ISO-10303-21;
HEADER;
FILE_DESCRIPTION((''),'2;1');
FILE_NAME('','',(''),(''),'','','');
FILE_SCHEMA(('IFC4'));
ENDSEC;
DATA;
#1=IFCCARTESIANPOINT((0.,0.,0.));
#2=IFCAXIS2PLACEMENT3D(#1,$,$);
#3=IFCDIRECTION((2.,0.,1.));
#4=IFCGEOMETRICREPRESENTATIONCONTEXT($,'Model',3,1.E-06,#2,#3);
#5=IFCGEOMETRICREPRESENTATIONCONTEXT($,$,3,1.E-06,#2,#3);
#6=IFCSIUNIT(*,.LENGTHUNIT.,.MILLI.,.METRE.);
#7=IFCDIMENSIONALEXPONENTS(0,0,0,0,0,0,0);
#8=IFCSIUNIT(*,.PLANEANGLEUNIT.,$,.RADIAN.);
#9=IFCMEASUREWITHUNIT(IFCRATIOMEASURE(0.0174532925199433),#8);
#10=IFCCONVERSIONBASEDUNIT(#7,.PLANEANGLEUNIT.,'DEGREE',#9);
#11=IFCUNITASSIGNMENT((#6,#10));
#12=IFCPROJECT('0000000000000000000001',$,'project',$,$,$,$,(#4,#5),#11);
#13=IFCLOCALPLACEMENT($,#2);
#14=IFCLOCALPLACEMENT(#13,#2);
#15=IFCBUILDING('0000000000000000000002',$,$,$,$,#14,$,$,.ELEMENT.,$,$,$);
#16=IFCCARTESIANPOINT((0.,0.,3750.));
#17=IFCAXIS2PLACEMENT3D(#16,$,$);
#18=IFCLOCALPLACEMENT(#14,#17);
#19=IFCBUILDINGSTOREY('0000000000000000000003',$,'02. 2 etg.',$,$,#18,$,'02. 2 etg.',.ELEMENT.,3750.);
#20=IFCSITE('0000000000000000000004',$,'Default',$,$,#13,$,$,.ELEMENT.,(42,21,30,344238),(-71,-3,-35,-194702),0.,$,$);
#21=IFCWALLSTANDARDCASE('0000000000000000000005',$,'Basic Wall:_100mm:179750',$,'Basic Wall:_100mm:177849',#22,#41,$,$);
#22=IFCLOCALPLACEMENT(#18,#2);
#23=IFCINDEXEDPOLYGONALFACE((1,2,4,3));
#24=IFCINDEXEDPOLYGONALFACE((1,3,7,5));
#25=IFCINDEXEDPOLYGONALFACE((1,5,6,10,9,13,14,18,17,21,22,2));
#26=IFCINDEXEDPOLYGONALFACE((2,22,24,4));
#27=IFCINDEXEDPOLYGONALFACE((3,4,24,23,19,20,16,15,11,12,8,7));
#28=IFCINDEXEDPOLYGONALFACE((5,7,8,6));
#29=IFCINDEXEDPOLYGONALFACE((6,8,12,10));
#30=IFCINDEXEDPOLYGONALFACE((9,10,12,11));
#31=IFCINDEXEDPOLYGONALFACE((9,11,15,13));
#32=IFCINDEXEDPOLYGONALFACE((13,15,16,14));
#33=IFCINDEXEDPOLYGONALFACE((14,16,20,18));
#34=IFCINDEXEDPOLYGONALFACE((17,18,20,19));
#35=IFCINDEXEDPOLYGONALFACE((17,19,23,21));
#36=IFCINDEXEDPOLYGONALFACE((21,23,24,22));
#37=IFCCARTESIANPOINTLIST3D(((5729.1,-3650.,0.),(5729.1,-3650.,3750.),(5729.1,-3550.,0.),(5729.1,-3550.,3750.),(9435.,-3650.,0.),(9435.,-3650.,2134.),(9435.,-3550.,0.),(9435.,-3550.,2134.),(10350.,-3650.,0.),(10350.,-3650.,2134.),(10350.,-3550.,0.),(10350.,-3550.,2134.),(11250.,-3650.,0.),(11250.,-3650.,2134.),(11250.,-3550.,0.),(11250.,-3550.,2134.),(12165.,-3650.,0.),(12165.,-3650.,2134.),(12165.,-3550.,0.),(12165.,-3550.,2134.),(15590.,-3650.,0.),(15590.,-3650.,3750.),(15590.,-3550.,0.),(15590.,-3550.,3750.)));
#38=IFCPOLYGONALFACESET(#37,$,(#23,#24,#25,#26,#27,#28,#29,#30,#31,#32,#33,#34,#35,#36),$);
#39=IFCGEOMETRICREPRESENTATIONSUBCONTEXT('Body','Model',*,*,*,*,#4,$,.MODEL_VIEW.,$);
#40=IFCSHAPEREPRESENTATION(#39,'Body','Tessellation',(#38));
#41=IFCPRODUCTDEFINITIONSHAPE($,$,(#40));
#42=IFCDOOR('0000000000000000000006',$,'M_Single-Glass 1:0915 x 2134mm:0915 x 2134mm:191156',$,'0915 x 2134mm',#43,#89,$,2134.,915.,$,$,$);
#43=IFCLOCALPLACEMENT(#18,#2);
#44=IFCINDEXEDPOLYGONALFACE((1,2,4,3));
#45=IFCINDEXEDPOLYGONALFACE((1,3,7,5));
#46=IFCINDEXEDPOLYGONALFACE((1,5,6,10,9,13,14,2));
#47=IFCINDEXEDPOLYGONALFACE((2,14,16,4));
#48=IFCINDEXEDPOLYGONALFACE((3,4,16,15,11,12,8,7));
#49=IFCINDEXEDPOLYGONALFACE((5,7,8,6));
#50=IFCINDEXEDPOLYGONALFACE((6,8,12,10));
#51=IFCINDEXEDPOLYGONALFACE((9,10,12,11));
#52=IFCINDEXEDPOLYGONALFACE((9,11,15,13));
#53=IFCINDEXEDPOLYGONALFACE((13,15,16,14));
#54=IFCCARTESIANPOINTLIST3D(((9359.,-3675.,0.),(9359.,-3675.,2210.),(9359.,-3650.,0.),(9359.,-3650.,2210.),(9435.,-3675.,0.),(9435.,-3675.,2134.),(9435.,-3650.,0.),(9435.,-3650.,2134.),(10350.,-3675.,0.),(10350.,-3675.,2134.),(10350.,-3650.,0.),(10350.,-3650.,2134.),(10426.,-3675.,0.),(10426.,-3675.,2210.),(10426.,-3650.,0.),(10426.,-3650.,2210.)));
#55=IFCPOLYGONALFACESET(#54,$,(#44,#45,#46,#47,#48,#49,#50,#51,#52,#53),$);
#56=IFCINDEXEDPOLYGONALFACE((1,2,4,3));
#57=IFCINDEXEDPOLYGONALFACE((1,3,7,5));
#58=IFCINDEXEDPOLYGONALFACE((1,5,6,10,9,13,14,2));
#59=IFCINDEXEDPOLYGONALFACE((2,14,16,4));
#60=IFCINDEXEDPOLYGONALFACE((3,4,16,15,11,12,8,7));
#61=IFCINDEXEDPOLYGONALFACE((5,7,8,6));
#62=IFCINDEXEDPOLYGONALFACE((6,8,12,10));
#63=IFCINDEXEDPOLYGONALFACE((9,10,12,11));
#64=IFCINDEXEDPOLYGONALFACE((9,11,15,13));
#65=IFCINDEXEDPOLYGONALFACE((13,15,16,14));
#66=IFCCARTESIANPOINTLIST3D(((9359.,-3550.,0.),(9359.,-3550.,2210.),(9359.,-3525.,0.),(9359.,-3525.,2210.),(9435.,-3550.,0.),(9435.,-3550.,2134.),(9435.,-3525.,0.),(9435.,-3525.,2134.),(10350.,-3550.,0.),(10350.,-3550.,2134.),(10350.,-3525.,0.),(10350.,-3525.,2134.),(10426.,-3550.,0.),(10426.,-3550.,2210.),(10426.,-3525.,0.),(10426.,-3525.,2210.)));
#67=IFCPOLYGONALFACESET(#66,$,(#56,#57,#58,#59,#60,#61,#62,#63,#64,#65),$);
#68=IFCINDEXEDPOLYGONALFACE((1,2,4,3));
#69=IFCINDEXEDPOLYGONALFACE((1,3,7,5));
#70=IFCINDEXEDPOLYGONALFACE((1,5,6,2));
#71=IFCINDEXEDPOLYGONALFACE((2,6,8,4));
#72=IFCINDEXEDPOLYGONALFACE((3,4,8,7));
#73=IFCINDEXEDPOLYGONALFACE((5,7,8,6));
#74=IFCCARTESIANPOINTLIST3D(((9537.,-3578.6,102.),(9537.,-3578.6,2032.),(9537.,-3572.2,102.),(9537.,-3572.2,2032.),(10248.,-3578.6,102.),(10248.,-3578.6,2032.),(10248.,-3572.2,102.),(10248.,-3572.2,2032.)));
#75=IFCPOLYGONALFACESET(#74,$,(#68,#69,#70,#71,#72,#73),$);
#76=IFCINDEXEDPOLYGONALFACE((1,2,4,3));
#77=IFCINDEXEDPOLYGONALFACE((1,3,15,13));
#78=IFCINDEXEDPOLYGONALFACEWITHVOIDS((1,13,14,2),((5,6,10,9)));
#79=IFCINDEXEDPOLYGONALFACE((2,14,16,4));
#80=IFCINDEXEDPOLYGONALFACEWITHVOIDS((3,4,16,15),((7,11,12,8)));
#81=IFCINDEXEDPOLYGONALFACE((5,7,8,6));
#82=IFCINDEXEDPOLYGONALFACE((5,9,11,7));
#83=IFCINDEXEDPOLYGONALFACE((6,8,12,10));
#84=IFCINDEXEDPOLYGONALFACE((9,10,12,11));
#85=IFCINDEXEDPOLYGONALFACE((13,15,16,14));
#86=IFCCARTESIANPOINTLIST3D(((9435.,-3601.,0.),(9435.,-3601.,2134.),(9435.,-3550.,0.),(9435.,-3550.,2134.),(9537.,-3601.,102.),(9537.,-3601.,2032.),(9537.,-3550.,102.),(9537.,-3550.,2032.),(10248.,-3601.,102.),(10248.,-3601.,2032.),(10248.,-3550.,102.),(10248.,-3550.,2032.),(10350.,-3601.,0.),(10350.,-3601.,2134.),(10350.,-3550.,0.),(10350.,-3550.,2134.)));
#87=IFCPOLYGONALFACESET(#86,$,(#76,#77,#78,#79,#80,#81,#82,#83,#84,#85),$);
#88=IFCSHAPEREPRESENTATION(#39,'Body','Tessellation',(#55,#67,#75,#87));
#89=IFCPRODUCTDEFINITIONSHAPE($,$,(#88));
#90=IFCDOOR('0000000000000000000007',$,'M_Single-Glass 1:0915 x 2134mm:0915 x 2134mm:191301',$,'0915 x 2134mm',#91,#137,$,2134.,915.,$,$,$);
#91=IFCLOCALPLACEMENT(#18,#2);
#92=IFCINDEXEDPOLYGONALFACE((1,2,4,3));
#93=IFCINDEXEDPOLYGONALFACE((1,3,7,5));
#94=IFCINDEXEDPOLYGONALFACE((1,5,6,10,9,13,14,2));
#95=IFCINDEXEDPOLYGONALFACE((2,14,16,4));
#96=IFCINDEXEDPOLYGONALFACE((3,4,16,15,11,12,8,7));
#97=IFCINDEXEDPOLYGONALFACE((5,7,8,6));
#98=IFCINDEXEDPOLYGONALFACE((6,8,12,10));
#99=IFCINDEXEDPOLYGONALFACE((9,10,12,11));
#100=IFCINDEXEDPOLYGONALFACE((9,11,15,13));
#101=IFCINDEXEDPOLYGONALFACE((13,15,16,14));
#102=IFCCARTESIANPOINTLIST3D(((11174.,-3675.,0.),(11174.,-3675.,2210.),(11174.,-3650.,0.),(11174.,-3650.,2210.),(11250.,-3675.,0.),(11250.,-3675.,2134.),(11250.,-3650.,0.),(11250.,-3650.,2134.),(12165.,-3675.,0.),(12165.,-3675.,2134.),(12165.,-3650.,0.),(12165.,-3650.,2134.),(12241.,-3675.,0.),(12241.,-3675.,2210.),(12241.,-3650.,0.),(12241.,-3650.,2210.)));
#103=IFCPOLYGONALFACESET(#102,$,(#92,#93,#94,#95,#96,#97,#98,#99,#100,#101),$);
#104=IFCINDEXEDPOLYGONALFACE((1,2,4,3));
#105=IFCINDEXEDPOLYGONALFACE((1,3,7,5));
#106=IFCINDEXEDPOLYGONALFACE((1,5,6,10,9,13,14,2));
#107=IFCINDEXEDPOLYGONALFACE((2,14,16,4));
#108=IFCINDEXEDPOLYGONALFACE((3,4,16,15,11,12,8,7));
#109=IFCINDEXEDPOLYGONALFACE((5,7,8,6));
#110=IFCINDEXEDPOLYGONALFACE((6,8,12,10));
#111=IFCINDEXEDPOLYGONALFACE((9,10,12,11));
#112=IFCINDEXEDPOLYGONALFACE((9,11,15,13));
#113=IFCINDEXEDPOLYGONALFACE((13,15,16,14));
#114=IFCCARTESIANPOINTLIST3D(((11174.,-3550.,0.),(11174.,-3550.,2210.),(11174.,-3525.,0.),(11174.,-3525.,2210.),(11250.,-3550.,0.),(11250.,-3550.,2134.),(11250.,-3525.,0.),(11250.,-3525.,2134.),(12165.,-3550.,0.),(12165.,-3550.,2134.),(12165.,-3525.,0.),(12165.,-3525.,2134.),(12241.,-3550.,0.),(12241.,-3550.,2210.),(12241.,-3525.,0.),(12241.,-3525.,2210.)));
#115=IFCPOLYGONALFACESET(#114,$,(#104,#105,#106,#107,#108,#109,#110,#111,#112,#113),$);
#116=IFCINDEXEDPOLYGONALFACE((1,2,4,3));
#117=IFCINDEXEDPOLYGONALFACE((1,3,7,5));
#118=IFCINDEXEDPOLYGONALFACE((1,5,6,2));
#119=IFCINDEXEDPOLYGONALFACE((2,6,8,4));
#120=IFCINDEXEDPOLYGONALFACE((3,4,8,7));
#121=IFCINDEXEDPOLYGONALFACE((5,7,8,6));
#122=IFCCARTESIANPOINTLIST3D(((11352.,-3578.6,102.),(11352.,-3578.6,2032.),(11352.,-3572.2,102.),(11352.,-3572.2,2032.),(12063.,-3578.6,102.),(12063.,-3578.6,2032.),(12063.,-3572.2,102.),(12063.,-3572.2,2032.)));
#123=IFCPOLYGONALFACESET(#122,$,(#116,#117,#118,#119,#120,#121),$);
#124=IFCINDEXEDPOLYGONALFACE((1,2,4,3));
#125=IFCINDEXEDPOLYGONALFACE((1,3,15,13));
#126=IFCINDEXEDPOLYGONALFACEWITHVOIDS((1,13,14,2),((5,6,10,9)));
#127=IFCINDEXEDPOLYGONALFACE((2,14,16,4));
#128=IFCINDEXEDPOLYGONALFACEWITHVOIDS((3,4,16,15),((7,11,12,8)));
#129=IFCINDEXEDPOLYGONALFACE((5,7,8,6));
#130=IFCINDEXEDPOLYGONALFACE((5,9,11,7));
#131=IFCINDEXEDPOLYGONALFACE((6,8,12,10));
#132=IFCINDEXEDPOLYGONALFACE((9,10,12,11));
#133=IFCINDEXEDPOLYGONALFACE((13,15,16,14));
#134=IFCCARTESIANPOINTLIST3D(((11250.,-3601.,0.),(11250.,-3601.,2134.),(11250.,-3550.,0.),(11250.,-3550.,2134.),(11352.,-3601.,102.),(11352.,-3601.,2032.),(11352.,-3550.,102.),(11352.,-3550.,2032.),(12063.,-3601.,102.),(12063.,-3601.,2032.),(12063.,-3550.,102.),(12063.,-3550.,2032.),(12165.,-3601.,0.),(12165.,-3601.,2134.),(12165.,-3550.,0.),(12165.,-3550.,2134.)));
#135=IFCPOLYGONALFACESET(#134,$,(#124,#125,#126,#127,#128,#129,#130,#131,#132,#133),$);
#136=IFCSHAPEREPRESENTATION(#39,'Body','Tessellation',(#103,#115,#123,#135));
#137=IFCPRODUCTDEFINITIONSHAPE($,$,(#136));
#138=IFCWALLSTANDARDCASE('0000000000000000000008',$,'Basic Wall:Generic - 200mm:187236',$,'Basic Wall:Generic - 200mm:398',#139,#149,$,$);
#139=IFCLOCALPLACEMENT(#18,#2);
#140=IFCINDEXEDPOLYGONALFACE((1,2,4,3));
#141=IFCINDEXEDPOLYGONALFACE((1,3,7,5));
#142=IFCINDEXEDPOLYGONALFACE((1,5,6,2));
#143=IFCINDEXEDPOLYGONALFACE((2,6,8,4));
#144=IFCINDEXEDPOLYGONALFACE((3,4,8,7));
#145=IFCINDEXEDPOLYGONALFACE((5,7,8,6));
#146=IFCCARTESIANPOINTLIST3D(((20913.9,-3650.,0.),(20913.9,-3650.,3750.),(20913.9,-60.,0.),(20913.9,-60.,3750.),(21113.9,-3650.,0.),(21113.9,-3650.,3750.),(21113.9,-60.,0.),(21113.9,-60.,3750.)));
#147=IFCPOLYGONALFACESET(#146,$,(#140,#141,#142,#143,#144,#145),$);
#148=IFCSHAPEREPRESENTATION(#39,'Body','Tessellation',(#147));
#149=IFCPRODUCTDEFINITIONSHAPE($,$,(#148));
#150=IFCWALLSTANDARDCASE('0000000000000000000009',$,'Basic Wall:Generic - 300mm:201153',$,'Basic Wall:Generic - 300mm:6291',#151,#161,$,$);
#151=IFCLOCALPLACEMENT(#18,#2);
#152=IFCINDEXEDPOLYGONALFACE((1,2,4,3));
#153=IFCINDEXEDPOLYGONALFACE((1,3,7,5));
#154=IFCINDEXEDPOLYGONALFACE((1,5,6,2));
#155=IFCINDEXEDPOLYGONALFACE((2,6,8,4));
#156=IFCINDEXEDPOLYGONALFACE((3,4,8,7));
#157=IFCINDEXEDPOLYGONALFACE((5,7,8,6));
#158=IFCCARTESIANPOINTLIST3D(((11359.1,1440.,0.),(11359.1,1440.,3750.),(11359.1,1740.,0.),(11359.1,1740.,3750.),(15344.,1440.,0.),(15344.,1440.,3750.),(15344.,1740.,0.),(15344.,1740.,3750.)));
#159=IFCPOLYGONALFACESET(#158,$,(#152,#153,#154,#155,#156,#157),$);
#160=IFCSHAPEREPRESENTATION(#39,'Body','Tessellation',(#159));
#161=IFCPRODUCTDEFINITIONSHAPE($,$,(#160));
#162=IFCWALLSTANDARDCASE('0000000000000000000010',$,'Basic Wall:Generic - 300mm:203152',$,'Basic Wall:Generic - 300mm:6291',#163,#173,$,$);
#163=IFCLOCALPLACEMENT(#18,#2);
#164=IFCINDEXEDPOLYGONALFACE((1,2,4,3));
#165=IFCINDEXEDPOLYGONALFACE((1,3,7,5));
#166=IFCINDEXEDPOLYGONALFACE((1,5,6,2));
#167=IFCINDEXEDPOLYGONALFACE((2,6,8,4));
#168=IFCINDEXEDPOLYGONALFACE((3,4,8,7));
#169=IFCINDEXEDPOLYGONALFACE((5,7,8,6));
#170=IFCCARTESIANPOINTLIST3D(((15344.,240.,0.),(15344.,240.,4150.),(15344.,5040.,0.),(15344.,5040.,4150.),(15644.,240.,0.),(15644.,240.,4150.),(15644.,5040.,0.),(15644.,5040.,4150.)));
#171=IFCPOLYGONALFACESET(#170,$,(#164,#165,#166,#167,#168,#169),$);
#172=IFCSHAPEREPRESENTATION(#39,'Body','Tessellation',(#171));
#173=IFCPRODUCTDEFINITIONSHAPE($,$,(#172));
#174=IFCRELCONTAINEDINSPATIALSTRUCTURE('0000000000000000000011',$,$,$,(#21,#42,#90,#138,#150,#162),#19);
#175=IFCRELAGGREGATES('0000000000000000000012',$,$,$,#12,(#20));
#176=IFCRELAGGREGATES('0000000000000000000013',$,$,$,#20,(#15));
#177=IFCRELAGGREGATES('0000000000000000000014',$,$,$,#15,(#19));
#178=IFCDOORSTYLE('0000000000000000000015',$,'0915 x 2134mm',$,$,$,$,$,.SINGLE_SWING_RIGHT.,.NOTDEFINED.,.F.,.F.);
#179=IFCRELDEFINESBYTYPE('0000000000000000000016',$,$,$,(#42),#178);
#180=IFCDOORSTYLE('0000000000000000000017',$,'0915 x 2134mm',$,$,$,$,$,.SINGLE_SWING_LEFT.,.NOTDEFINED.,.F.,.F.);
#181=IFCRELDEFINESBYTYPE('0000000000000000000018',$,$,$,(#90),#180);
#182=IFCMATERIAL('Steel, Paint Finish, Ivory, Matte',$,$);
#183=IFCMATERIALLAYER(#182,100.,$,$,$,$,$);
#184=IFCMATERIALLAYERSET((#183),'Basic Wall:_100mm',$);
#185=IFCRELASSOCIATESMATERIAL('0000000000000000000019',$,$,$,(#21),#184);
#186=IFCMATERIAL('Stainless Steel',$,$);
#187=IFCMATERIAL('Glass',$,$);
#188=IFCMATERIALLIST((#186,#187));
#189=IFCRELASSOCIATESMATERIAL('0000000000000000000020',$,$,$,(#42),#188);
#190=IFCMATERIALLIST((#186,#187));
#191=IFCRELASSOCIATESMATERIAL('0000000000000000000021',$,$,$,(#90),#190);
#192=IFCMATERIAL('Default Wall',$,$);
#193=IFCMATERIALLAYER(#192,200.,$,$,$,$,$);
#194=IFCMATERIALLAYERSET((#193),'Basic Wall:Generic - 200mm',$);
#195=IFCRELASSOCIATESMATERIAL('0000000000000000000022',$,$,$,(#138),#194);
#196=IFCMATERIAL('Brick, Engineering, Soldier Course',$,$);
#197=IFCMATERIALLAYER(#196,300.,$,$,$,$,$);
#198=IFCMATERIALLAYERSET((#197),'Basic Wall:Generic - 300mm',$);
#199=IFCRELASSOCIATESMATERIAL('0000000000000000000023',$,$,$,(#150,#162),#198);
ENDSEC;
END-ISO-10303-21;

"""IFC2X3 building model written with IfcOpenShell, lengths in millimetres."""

from ifc_helpers import new_model, entity, si_unit, converted_unit, direction, frame, frame_2d, origin, origin_2d_with_axis, place, context, subcontext, project, spatial, polyline, rectangle, outline, extrude, source, transform, mapped, material, material_list, layer, layer_set, layer_usage, type_object, type_shapes, element, fill, save


model = new_model("IFC2X3")

# Units and contexts
model_context = context("Model", 3, precision=1e-06, world=origin(), true_north=direction((2.0, 0.0, 1.0)))
context_of_model = context(None, 3, precision=1e-06, world=origin(), true_north=direction((2.0, 0.0, 1.0)))
body_context = subcontext(model_context, "Body", "Model", "MODEL_VIEW")
ifc_project = project(units=[si_unit("LENGTHUNIT", "METRE", prefix="MILLI"), converted_unit("PLANEANGLEUNIT", "DEGREE", entity("IfcRatioMeasure", 0.0174532925199433), si_unit("PLANEANGLEUNIT", "RADIAN"), dimensions=[0, 0, 0, 0, 0, 0, 0])], contexts=[model_context, context_of_model])

# Site, building, storey
site_placement = place(None, origin())
site = spatial("IfcSite", under=ifc_project, at=site_placement, Name="Default", CompositionType="ELEMENT", RefLatitude=(42, 21, 30, 344238), RefLongitude=(-71, -3, -35, -194702), RefElevation=0.0)
building_placement = place(site_placement, origin())
building = spatial("IfcBuilding", under=site, at=building_placement, CompositionType="ELEMENT")
storey_placement = place(building_placement, frame((0.0, 0.0, 3750.0)))
storey = spatial("IfcBuildingStorey", under=building, at=storey_placement, Name="02. 2 etg.", LongName="02. 2 etg.", CompositionType="ELEMENT", Elevation=3750.0)

# Shared definitions
ifc_material_1 = material(Name="Glass")

# Wall, openings, doors
ifc_material_2 = material(Name="Steel, Paint Finish, Ivory, Matte")
ifc_layer_1 = layer(ifc_material_2, 100.0)
ifc_layer_set_1 = layer_set([ifc_layer_1], Name="Basic Wall:_100mm")
ifc_layer_usage_1 = layer_usage(ifc_layer_set_1, "AXIS2", "NEGATIVE", 50.0)
wall_1_placement = place(storey_placement, frame((15590.0, -3600.0, 0.0), z_axis=(0.0, 0.0, 1.0), x_axis=(-1.0, 0.0, 0.0)))
wall_1 = element("IfcWallStandardCase", 1, at=wall_1_placement, inside=storey, material=ifc_layer_usage_1, Name="Basic Wall:_100mm:179750", ObjectType="Basic Wall:_100mm:177849", context=body_context, shape_type="SweptSolid", body=[
    extrude(rectangle(XDim=9860.9, YDim=100.0, at=frame_2d((4930.4, 0.0), x_axis=(-1.0, 0.0))), origin(), (0.0, 0.0, 1.0), 3750.0),
])
opening_1_placement = place(wall_1_placement, frame((6155.0, 50.0, 0.0)))
opening_1 = element("IfcOpeningElement", 2, at=opening_1_placement, cuts=wall_1, ObjectType="Opening", context=body_context, shape_type="SweptSolid", body=[
    extrude(rectangle(XDim=915.0, YDim=2134.0, at=frame_2d((1067.0, 457.5), x_axis=(0.0, 1.0))), frame((0.0, 0.0, 0.0), z_axis=(0.0, -1.0, 0.0), x_axis=(0.0, 0.0, 1.0)), (0.0, 0.0, 1.0), 100.0),
])
opening_2_placement = place(wall_1_placement, frame((4340.0, 50.0, 0.0)))
opening_2 = element("IfcOpeningElement", 3, at=opening_2_placement, cuts=wall_1, ObjectType="Opening", context=body_context, shape_type="SweptSolid", body=[
    extrude(rectangle(XDim=915.0, YDim=2134.0, at=frame_2d((1067.0, 457.5), x_axis=(0.0, -1.0))), frame((0.0, 0.0, 0.0), z_axis=(0.0, -1.0, 0.0), x_axis=(0.0, 0.0, 1.0)), (0.0, 0.0, 1.0), 100.0),
])
ifc_material_3 = material(Name="Stainless Steel")
ifc_material_list_1 = material_list([ifc_material_3, ifc_material_1])
door_style_1 = type_object("IfcDoorStyle", Name="0915 x 2134mm", ConstructionType="NOTDEFINED", OperationType="SINGLE_SWING_RIGHT", ParameterTakesPrecedence=False, Sizeable=False)
shared_shape_1 = source(origin(), body_context, "Body", "SweptSolid", [
    extrude(outline(polyline([(-457.5, -1048.0), (-457.5, 1086.0), (-533.5, 1086.0), (-533.5, -1124.0), (533.5, -1124.0), (533.5, 1086.0), (457.5, 1086.0), (457.5, -1048.0), (-457.5, -1048.0)])), frame((457.5, -25.0, 1086.0), z_axis=(0.0, -1.0, 0.0), x_axis=(-1.0, 0.0, 0.0)), (0.0, 0.0, -1.0), 25.0),
    extrude(outline(polyline([(-457.5, -1048.0), (-457.5, 1086.0), (-533.5, 1086.0), (-533.5, -1124.0), (533.5, -1124.0), (533.5, 1086.0), (457.5, 1086.0), (457.5, -1048.0), (-457.5, -1048.0)])), frame((457.5, 100.0, 1086.0), z_axis=(0.0, -1.0, 0.0), x_axis=(-1.0, 0.0, 0.0)), (0.0, 0.0, -1.0), 25.0),
    extrude(rectangle(XDim=6.3, YDim=711.0, at=frame_2d((0.0, 0.0), x_axis=(1.0, 0.0))), frame((457.5, 74.6, 102.0), z_axis=(0.0, 0.0, 1.0), x_axis=(0.0, 1.0, 0.0)), (0.0, 0.0, 1.0), 1930.0),
    extrude(outline(polyline([(-1067.0, -457.5), (1067.0, -457.5), (1067.0, 457.5), (-1067.0, 457.5), (-1067.0, -457.5)]), holes=[polyline([(-965.0, 355.5), (965.0, 355.5), (965.0, -355.5), (-965.0, -355.5), (-965.0, 355.5)])]), frame((457.5, 49.0, 1067.0), z_axis=(0.0, 1.0, 0.0), x_axis=(0.0, 0.0, -1.0)), (0.0, 0.0, 1.0), 51.0),
])
type_shapes(door_style_1, [shared_shape_1])
door_1_placement = place(opening_1_placement, frame((0.0, 0.0, 0.0), z_axis=(0.0, 0.0, 1.0), x_axis=(-1.0, 0.0, 0.0)))
door_1 = element("IfcDoor", 4, at=door_1_placement, inside=storey, type_object=door_style_1, material=ifc_material_list_1, Name="M_Single-Glass 1:0915 x 2134mm:0915 x 2134mm:191156", ObjectType="0915 x 2134mm", OverallHeight=2134.0, OverallWidth=915.0, context=body_context, shape_type="MappedRepresentation", body=[
    mapped(shared_shape_1, transform((0.0, 0.0, 0.0), scale=1.0)),
])
fill(opening_1, door_1)
ifc_material_list_2 = material_list([ifc_material_3, ifc_material_1])
door_style_2 = type_object("IfcDoorStyle", Name="0915 x 2134mm", ConstructionType="NOTDEFINED", OperationType="SINGLE_SWING_LEFT", ParameterTakesPrecedence=False, Sizeable=False)
shared_shape_2 = source(origin(), body_context, "Body", "SweptSolid", [
    extrude(outline(polyline([(-457.5, -1048.0), (-457.5, 1086.0), (-533.5, 1086.0), (-533.5, -1124.0), (533.5, -1124.0), (533.5, 1086.0), (457.5, 1086.0), (457.5, -1048.0), (-457.5, -1048.0)])), frame((457.5, 0.0, 1086.0), z_axis=(0.0, 1.0, 0.0), x_axis=(1.0, 0.0, 0.0)), (0.0, 0.0, -1.0), 25.0),
    extrude(outline(polyline([(-457.5, -1048.0), (-457.5, 1086.0), (-533.5, 1086.0), (-533.5, -1124.0), (533.5, -1124.0), (533.5, 1086.0), (457.5, 1086.0), (457.5, -1048.0), (-457.5, -1048.0)])), frame((457.5, 125.0, 1086.0), z_axis=(0.0, 1.0, 0.0), x_axis=(1.0, 0.0, 0.0)), (0.0, 0.0, -1.0), 25.0),
    extrude(rectangle(XDim=711.0, YDim=6.3, at=origin_2d_with_axis()), frame((457.5, 74.6, 102.0)), (0.0, 0.0, 1.0), 1930.0),
    extrude(outline(polyline([(-1067.0, -457.5), (1067.0, -457.5), (1067.0, 457.5), (-1067.0, 457.5), (-1067.0, -457.5)]), holes=[polyline([(-965.0, 355.5), (965.0, 355.5), (965.0, -355.5), (-965.0, -355.5), (-965.0, 355.5)])]), frame((457.5, 100.0, 1067.0), z_axis=(0.0, -1.0, 0.0), x_axis=(0.0, 0.0, -1.0)), (0.0, 0.0, 1.0), 51.0),
])
type_shapes(door_style_2, [shared_shape_2])
door_2_placement = place(opening_2_placement, frame((0.0, 0.0, 0.0), z_axis=(0.0, 0.0, 1.0), x_axis=(-1.0, 0.0, 0.0)))
door_2 = element("IfcDoor", 5, at=door_2_placement, inside=storey, type_object=door_style_2, material=ifc_material_list_2, Name="M_Single-Glass 1:0915 x 2134mm:0915 x 2134mm:191301", ObjectType="0915 x 2134mm", OverallHeight=2134.0, OverallWidth=915.0, context=body_context, shape_type="MappedRepresentation", body=[
    mapped(shared_shape_2, transform((0.0, 0.0, 0.0), scale=1.0)),
])
fill(opening_2, door_2)

# Wall
ifc_material_4 = material(Name="Default Wall")
ifc_layer_2 = layer(ifc_material_4, 200.0)
ifc_layer_set_2 = layer_set([ifc_layer_2], Name="Basic Wall:Generic - 200mm")
ifc_layer_usage_2 = layer_usage(ifc_layer_set_2, "AXIS2", "NEGATIVE", 100.0)
wall_2_placement = place(storey_placement, frame((21013.9, -60.0, 0.0), z_axis=(0.0, 0.0, 1.0), x_axis=(0.0, -1.0, 0.0)))
element("IfcWallStandardCase", 6, at=wall_2_placement, inside=storey, material=ifc_layer_usage_2, Name="Basic Wall:Generic - 200mm:187236", ObjectType="Basic Wall:Generic - 200mm:398", context=body_context, shape_type="SweptSolid", body=[
    extrude(rectangle(XDim=3590.0, YDim=200.0, at=frame_2d((1795.0, 0.0), x_axis=(-1.0, 0.0))), origin(), (0.0, 0.0, 1.0), 3750.0),
])

# Walls
ifc_material_5 = material(Name="Brick, Engineering, Soldier Course")
ifc_layer_3 = layer(ifc_material_5, 300.0)
ifc_layer_set_3 = layer_set([ifc_layer_3], Name="Basic Wall:Generic - 300mm")
ifc_layer_usage_3 = layer_usage(ifc_layer_set_3, "AXIS2", "NEGATIVE", 150.0)
wall_3_placement = place(storey_placement, frame((15344.0, 1590.0, 0.0), z_axis=(0.0, 0.0, 1.0), x_axis=(-1.0, 0.0, 0.0)))
element("IfcWallStandardCase", 7, at=wall_3_placement, inside=storey, material=ifc_layer_usage_3, Name="Basic Wall:Generic - 300mm:201153", ObjectType="Basic Wall:Generic - 300mm:6291", context=body_context, shape_type="SweptSolid", body=[
    extrude(rectangle(XDim=3984.9, YDim=300.0, at=frame_2d((1992.4, 0.0), x_axis=(-1.0, 0.0))), origin(), (0.0, 0.0, 1.0), 3750.0),
])
ifc_layer_usage_4 = layer_usage(ifc_layer_set_3, "AXIS2", "NEGATIVE", 150.0)
wall_4_placement = place(storey_placement, frame((15494.0, 240.0, 0.0), z_axis=(0.0, 0.0, 1.0), x_axis=(0.0, 1.0, 0.0)))
element("IfcWallStandardCase", 8, at=wall_4_placement, inside=storey, material=ifc_layer_usage_4, Name="Basic Wall:Generic - 300mm:203152", ObjectType="Basic Wall:Generic - 300mm:6291", context=body_context, shape_type="SweptSolid", body=[
    extrude(rectangle(XDim=4800.0, YDim=300.0, at=frame_2d((2400.0, 0.0), x_axis=(-1.0, 0.0))), origin(), (0.0, 0.0, 1.0), 4150.0),
])

save(model, "model.ifc")
